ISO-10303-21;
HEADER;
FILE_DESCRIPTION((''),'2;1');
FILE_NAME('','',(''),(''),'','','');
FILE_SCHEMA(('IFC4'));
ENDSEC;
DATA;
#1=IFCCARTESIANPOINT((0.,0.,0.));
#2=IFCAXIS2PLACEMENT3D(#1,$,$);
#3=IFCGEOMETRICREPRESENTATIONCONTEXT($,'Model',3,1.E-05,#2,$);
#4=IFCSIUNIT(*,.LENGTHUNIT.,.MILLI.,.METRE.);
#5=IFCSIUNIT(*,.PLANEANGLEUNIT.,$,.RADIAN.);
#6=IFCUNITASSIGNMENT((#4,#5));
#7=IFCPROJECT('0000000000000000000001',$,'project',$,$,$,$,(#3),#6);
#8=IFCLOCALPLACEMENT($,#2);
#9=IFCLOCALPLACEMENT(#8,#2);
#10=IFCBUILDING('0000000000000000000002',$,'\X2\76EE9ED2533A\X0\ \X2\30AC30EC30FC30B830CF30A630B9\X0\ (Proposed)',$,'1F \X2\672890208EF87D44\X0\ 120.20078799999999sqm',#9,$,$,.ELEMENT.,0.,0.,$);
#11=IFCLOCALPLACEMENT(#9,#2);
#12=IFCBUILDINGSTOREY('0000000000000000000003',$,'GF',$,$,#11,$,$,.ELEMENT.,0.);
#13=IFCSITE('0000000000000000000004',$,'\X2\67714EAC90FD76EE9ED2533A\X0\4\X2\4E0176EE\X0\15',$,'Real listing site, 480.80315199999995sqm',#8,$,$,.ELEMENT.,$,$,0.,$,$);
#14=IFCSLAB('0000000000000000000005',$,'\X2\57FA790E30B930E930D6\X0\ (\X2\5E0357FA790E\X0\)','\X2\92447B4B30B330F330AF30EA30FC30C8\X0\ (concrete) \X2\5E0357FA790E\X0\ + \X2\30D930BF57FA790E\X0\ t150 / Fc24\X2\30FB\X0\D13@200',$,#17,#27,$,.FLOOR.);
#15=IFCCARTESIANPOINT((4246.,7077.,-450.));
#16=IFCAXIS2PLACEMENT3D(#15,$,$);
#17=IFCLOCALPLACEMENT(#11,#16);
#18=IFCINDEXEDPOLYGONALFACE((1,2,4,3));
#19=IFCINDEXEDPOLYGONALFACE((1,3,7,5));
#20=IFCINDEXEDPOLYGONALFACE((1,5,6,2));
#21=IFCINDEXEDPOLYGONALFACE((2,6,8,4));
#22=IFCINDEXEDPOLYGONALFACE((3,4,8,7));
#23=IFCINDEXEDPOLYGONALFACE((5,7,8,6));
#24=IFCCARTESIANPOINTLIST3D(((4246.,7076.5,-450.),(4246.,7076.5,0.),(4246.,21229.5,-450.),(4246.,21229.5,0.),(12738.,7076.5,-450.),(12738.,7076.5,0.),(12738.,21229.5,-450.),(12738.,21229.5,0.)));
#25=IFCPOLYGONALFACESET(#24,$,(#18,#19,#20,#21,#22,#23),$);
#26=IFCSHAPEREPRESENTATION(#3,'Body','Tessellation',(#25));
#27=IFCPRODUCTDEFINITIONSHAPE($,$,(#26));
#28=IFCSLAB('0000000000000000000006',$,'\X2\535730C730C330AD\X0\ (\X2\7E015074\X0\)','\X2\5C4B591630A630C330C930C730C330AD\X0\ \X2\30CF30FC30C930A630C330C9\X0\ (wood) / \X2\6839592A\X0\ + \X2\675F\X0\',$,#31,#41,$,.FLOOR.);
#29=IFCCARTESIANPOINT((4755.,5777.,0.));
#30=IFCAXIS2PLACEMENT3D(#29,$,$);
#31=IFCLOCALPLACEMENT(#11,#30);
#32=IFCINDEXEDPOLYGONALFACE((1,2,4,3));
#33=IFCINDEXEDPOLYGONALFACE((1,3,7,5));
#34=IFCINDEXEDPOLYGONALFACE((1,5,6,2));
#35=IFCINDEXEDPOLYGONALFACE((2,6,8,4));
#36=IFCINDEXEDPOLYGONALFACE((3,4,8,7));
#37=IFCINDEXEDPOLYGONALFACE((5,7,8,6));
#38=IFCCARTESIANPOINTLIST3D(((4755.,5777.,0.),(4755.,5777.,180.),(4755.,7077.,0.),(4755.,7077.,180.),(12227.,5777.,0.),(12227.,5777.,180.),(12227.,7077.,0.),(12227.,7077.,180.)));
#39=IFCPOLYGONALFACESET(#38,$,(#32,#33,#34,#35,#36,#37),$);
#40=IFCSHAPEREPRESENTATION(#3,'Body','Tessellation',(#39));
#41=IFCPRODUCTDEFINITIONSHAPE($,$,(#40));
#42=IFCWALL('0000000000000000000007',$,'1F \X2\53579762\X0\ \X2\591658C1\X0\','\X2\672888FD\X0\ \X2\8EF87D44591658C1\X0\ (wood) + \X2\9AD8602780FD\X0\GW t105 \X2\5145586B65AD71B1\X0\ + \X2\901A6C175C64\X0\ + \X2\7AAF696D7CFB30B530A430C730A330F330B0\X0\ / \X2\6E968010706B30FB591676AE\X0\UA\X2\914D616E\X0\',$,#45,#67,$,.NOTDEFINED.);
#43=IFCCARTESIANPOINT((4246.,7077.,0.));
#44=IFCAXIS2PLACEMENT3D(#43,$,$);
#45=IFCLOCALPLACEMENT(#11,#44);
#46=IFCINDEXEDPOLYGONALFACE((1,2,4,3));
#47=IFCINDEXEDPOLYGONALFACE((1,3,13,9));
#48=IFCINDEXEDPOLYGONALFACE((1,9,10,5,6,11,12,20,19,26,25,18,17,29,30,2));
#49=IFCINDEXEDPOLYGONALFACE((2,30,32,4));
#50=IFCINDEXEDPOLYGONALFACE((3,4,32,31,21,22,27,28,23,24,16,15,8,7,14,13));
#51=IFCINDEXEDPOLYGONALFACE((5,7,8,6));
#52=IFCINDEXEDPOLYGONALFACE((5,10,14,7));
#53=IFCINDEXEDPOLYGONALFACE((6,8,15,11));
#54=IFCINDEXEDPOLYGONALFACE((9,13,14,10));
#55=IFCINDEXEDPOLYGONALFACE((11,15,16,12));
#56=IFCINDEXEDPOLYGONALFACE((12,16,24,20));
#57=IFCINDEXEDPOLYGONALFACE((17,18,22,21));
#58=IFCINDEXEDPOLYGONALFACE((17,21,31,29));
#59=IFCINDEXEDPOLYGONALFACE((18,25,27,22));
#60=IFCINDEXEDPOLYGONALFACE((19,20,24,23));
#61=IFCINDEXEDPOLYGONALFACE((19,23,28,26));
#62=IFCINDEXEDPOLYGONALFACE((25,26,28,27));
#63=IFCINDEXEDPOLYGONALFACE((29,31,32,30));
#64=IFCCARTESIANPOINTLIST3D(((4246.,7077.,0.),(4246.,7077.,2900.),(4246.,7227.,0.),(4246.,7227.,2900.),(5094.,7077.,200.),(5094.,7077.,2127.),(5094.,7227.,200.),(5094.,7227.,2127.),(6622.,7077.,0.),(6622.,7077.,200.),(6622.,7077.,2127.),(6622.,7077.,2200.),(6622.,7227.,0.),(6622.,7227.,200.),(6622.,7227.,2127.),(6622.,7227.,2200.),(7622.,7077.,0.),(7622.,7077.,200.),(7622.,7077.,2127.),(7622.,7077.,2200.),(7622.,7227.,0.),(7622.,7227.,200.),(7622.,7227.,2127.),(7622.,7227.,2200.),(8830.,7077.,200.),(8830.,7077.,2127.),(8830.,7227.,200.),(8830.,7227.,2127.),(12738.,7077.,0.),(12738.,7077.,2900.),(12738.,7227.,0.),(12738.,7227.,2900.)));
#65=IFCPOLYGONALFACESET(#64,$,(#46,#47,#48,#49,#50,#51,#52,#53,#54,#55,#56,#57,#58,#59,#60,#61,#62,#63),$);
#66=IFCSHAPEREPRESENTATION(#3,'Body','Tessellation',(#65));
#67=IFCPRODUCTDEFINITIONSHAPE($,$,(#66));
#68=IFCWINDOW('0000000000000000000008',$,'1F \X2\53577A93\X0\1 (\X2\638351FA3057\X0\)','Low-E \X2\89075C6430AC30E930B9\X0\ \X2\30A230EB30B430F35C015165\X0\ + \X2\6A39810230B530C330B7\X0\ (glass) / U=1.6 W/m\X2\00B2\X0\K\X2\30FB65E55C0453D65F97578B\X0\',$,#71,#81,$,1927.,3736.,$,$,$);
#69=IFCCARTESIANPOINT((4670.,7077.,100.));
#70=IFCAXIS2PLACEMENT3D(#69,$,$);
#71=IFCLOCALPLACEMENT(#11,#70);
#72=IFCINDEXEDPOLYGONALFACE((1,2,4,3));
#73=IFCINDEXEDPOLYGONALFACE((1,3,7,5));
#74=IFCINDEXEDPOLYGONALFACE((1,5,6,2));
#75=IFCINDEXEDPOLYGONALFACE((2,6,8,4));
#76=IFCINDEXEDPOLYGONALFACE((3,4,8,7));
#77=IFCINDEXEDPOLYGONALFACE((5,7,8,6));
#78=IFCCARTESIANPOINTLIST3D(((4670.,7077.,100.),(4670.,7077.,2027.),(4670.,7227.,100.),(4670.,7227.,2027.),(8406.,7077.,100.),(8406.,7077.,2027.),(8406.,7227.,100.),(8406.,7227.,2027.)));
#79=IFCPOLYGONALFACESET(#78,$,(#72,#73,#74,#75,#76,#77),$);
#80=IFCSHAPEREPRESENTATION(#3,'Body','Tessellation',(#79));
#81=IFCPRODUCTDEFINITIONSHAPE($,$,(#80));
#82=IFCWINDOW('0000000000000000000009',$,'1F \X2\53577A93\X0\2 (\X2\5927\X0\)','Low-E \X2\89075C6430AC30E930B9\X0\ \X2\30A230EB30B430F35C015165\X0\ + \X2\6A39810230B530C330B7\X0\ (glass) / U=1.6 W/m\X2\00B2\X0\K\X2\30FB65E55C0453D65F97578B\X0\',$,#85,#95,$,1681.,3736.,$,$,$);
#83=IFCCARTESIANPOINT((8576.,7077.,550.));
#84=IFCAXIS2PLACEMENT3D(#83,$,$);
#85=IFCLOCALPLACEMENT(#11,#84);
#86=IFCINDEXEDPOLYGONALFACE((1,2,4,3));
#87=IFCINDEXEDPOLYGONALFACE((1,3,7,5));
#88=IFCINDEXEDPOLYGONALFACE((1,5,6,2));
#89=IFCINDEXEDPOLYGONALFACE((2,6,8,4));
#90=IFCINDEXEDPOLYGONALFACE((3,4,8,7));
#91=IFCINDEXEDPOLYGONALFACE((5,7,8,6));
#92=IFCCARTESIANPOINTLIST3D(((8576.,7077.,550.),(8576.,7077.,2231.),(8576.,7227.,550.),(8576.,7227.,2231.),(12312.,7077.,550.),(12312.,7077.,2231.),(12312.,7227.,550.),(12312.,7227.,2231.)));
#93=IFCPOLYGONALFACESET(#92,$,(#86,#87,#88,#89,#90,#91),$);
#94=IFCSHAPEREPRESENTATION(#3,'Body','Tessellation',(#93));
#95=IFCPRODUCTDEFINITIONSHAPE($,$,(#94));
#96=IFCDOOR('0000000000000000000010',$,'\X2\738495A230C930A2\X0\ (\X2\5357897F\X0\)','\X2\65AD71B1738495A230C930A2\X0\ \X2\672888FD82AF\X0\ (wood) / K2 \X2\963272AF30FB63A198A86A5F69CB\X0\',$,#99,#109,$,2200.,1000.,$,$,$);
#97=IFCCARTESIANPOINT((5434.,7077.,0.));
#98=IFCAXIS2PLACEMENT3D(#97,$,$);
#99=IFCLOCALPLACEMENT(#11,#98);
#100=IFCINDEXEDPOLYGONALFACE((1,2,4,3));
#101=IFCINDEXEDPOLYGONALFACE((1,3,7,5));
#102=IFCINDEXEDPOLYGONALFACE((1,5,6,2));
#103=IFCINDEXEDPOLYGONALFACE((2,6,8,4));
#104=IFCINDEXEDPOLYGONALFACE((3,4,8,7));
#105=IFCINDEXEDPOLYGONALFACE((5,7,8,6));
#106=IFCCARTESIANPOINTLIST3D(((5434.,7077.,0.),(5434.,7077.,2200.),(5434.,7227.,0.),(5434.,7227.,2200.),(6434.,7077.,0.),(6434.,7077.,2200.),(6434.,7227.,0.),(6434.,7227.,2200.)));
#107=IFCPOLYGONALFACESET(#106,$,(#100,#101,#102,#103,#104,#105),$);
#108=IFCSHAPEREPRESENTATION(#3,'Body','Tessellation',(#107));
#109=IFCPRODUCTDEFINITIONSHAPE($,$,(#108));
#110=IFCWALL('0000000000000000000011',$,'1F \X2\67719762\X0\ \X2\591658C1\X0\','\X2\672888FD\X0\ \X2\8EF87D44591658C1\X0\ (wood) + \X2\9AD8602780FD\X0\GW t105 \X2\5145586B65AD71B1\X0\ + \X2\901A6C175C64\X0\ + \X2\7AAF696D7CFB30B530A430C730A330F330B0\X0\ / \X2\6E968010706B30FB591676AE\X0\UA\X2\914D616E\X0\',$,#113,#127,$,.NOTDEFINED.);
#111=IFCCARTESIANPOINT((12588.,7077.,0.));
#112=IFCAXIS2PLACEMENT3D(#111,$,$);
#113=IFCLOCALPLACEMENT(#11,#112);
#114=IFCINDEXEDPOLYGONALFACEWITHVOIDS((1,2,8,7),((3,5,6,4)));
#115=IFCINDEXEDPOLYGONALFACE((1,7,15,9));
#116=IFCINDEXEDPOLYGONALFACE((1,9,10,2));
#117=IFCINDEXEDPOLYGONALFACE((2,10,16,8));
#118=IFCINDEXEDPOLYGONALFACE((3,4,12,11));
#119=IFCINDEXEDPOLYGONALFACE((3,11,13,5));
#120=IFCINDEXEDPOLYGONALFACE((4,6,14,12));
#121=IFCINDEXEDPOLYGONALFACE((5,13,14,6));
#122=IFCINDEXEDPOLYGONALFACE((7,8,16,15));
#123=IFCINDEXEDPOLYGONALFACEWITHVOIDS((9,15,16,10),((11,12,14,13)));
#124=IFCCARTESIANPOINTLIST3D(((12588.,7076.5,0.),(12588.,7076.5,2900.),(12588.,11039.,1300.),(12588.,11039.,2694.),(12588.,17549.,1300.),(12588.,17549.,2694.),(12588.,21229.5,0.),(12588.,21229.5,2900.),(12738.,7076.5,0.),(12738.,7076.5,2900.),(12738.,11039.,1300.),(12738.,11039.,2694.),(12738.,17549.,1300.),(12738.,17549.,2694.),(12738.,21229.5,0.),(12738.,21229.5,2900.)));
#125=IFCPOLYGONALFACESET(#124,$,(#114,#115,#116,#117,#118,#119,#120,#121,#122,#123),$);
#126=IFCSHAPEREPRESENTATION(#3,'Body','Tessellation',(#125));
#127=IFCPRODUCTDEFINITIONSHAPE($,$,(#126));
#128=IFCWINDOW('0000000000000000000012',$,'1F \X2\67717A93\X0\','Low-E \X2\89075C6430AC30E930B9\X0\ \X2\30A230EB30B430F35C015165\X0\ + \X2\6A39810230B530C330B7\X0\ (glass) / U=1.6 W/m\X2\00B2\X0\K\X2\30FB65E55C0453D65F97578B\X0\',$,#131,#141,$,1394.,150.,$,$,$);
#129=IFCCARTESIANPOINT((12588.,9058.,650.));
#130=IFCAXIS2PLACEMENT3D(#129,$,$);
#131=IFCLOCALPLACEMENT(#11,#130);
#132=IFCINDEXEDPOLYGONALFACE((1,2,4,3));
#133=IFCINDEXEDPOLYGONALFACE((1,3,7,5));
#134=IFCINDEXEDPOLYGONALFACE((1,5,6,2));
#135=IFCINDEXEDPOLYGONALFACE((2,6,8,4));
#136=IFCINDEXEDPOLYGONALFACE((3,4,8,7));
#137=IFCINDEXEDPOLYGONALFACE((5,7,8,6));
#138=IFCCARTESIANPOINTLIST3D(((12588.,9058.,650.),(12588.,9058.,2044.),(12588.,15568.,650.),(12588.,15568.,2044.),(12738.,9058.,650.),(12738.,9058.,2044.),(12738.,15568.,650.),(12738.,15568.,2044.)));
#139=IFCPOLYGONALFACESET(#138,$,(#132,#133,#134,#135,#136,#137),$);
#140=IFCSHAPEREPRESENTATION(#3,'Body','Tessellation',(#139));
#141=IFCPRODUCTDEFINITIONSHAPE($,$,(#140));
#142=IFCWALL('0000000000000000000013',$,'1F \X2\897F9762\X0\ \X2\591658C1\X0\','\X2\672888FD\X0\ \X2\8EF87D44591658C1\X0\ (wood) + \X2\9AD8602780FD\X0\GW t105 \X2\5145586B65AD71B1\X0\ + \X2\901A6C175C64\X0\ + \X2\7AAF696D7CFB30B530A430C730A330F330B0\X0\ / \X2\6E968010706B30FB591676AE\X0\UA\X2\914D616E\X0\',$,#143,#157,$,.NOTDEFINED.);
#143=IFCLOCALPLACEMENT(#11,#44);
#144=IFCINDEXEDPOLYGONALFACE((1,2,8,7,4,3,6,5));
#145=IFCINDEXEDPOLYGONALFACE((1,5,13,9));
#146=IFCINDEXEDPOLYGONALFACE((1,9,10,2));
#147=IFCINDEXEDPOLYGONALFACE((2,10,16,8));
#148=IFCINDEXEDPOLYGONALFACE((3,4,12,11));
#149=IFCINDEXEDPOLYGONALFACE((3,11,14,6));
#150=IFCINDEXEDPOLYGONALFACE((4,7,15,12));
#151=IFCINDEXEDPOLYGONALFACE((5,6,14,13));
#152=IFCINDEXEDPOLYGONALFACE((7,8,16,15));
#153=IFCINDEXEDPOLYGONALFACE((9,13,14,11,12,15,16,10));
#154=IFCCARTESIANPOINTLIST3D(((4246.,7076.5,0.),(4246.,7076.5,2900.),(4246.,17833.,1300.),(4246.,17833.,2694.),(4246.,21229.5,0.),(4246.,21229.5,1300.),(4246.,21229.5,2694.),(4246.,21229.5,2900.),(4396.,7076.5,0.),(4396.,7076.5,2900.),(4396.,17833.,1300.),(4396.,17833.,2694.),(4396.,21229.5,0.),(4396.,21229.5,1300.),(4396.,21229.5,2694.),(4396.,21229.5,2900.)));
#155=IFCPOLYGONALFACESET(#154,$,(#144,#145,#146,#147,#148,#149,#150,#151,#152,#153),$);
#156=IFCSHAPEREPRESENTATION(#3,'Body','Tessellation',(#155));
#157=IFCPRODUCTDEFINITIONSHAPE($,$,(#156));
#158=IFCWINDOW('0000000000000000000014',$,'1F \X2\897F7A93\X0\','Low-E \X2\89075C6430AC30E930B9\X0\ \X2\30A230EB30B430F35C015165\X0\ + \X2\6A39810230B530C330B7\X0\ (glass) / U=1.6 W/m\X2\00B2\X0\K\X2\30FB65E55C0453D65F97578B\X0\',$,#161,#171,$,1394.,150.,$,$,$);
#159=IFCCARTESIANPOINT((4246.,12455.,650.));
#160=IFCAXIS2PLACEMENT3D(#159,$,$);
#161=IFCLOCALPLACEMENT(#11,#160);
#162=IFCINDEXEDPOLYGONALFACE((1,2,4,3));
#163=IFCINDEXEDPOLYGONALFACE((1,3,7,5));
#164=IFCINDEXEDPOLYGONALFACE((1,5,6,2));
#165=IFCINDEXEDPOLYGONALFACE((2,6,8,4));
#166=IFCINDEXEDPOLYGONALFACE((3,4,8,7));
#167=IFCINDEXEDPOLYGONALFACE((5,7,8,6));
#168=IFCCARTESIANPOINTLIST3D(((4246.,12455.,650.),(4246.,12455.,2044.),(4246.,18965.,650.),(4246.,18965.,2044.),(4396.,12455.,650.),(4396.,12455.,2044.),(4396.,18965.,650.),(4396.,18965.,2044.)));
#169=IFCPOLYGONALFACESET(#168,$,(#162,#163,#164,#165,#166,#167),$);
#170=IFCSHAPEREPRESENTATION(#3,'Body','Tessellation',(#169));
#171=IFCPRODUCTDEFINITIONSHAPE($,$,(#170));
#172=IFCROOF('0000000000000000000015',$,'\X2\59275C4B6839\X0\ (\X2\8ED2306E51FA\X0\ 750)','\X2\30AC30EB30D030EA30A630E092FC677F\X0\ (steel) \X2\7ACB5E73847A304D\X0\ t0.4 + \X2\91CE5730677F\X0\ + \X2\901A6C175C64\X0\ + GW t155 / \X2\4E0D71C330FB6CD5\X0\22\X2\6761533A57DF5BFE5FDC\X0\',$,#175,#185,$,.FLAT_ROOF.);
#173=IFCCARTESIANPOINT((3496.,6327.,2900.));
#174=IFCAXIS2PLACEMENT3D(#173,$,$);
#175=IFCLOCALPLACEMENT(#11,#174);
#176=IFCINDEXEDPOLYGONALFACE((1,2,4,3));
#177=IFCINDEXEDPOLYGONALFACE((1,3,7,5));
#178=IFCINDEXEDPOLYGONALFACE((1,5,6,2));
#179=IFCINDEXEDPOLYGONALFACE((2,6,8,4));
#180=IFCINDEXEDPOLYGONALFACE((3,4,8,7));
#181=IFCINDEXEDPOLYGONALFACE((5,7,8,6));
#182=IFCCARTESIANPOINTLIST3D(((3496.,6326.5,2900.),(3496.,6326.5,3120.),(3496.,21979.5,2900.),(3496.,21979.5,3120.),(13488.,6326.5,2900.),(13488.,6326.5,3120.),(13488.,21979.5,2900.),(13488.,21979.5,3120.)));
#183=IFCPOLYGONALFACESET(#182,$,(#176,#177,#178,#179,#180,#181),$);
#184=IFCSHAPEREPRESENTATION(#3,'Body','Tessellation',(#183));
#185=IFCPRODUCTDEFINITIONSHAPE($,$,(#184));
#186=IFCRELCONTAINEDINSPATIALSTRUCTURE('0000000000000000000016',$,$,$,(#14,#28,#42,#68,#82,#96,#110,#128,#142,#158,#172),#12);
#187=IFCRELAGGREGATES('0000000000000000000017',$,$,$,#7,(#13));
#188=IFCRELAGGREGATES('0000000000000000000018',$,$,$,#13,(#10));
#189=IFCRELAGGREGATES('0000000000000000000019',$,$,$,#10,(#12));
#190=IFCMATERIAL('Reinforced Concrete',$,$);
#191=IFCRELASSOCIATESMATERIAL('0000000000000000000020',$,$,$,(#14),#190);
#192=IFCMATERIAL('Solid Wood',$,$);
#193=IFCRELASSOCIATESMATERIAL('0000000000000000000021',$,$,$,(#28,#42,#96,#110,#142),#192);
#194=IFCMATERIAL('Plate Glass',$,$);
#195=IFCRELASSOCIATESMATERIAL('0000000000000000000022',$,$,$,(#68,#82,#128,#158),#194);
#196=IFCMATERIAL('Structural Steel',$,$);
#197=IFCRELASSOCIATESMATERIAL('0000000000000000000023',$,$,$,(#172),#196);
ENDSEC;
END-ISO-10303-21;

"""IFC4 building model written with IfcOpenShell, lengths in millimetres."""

from ifc_helpers import new_model, si_unit, frame, frame_2d, origin, place, context, project, spatial, rectangle, extrude, material, element, fill, save


model = new_model("IFC4")

# Units and contexts
model_context = context("Model", 3, precision=1e-05, world=origin())
ifc_project = project(units=[si_unit("LENGTHUNIT", "METRE", prefix="MILLI"), si_unit("PLANEANGLEUNIT", "RADIAN")], contexts=[model_context])

# Site, building, storey
site_placement = place(None, origin())
site = spatial("IfcSite", under=ifc_project, at=site_placement, Name="東京都目黒区4丁目15", ObjectType="Real listing site, 480.80315199999995sqm", CompositionType="ELEMENT", RefElevation=0.0)
building_placement = place(site_placement, origin())
building = spatial("IfcBuilding", under=site, at=building_placement, Name="目黒区 ガレージハウス (Proposed)", ObjectType="1F 木造軸組 120.20078799999999sqm", CompositionType="ELEMENT", ElevationOfRefHeight=0.0, ElevationOfTerrain=0.0)
storey_placement = place(building_placement, origin())
storey = spatial("IfcBuildingStorey", under=building, at=storey_placement, Name="GF", CompositionType="ELEMENT", Elevation=0.0)

# Slabs
ifc_material_1 = material(Name="Reinforced Concrete")
slab_1_placement = place(storey_placement, frame((4246.0, 7077.0, -450.0)))
element("IfcSlab", 1, at=slab_1_placement, inside=storey, material=ifc_material_1, Name="基礎スラブ (布基礎)", Description="鉄筋コンクリート (concrete) 布基礎 + ベタ基礎 t150 / Fc24・D13@200", PredefinedType="FLOOR", context=model_context, shape_type="SweptSolid", body=[
    extrude(rectangle(XDim=8492.0, YDim=14153.0, at=frame_2d((4246.0, 7076.0))), frame((4246.0, 7077.0, -450.0)), (0.0, 0.0, 1.0), 450.0),
])
ifc_material_2 = material(Name="Solid Wood")
slab_2_placement = place(storey_placement, frame((4755.0, 5777.0, 0.0)))
element("IfcSlab", 2, at=slab_2_placement, inside=storey, material=ifc_material_2, Name="南デッキ (縁側)", Description="屋外ウッドデッキ ハードウッド (wood) / 根太 + 束", PredefinedType="FLOOR", context=model_context, shape_type="SweptSolid", body=[
    extrude(rectangle(XDim=7472.0, YDim=1300.0, at=frame_2d((3736.0, 650.0))), frame((4755.0, 5777.0, 0.0)), (0.0, 0.0, 1.0), 180.0),
])

# Wall, openings, windows, door
wall_1_placement = place(storey_placement, frame((4246.0, 7077.0, 0.0)))
wall_1 = element("IfcWall", 3, at=wall_1_placement, inside=storey, material=ifc_material_2, Name="1F 南面 外壁", Description="木製 軸組外壁 (wood) + 高性能GW t105 充填断熱 + 通気層 + 窯業系サイディング / 準耐火・外皮UA配慮", PredefinedType="NOTDEFINED", context=model_context, shape_type="SweptSolid", body=[
    extrude(rectangle(XDim=8492.0, YDim=150.0, at=frame_2d((4246.0, 75.0))), frame((4246.0, 7077.0, 0.0)), (0.0, 0.0, 1.0), 2900.0),
])
opening_1_placement = place(storey_placement, frame((4670.0, 7077.0, 100.0)))
opening_1 = element("IfcOpeningElement", 4, at=opening_1_placement, cuts=wall_1, PredefinedType="NOTDEFINED", context=model_context, shape_type="SweptSolid", body=[
    extrude(rectangle(XDim=3736.0, YDim=150.0, at=frame_2d((1868.0, 75.0))), frame((4670.0, 7077.0, 100.0)), (0.0, 0.0, 1.0), 1927.0),
])
opening_2_placement = place(storey_placement, frame((8576.0, 7077.0, 550.0)))
opening_2 = element("IfcOpeningElement", 5, at=opening_2_placement, cuts=wall_1, PredefinedType="NOTDEFINED", context=model_context, shape_type="SweptSolid", body=[
    extrude(rectangle(XDim=3736.0, YDim=150.0, at=frame_2d((1868.0, 75.0))), frame((8576.0, 7077.0, 550.0)), (0.0, 0.0, 1.0), 1681.0),
])
opening_3_placement = place(storey_placement, frame((5434.0, 7077.0, 0.0)))
opening_3 = element("IfcOpeningElement", 6, at=opening_3_placement, cuts=wall_1, PredefinedType="NOTDEFINED", context=model_context, shape_type="SweptSolid", body=[
    extrude(rectangle(XDim=1000.0, YDim=150.0, at=frame_2d((500.0, 75.0))), frame((5434.0, 7077.0, 0.0)), (0.0, 0.0, 1.0), 2200.0),
])
ifc_material_3 = material(Name="Plate Glass")
window_1_placement = place(storey_placement, frame((4670.0, 7077.0, 100.0)))
window_1 = element("IfcWindow", 7, at=window_1_placement, inside=storey, material=ifc_material_3, Name="1F 南窓1 (掃出し)", Description="Low-E 複層ガラス アルゴン封入 + 樹脂サッシ (glass) / U=1.6 W/m²K・日射取得型", OverallHeight=1927.0, OverallWidth=3736.0, context=model_context, shape_type="SweptSolid", body=[
    extrude(rectangle(XDim=3736.0, YDim=150.0, at=frame_2d((1868.0, 75.0))), frame((4670.0, 7077.0, 100.0)), (0.0, 0.0, 1.0), 1927.0),
])
fill(opening_1, window_1)
window_2_placement = place(storey_placement, frame((8576.0, 7077.0, 550.0)))
window_2 = element("IfcWindow", 8, at=window_2_placement, inside=storey, material=ifc_material_3, Name="1F 南窓2 (大)", Description="Low-E 複層ガラス アルゴン封入 + 樹脂サッシ (glass) / U=1.6 W/m²K・日射取得型", OverallHeight=1681.0, OverallWidth=3736.0, context=model_context, shape_type="SweptSolid", body=[
    extrude(rectangle(XDim=3736.0, YDim=150.0, at=frame_2d((1868.0, 75.0))), frame((8576.0, 7077.0, 550.0)), (0.0, 0.0, 1.0), 1681.0),
])
fill(opening_2, window_2)
door_placement = place(storey_placement, frame((5434.0, 7077.0, 0.0)))
door = element("IfcDoor", 9, at=door_placement, inside=storey, material=ifc_material_2, Name="玄関ドア (南西)", Description="断熱玄関ドア 木製芯 (wood) / K2 防犯・採風機構", OverallHeight=2200.0, OverallWidth=1000.0, context=model_context, shape_type="SweptSolid", body=[
    extrude(rectangle(XDim=1000.0, YDim=150.0, at=frame_2d((500.0, 75.0))), frame((5434.0, 7077.0, 0.0)), (0.0, 0.0, 1.0), 2200.0),
])
fill(opening_3, door)

# Walls, openings, windows
wall_2_placement = place(storey_placement, frame((12588.0, 7077.0, 0.0)))
wall_2 = element("IfcWall", 10, at=wall_2_placement, inside=storey, material=ifc_material_2, Name="1F 東面 外壁", Description="木製 軸組外壁 (wood) + 高性能GW t105 充填断熱 + 通気層 + 窯業系サイディング / 準耐火・外皮UA配慮", PredefinedType="NOTDEFINED", context=model_context, shape_type="SweptSolid", body=[
    extrude(rectangle(XDim=150.0, YDim=14153.0, at=frame_2d((75.0, 7076.0))), frame((12588.0, 7077.0, 0.0)), (0.0, 0.0, 1.0), 2900.0),
])
opening_4_placement = place(storey_placement, frame((12588.0, 9058.0, 650.0)))
opening_4 = element("IfcOpeningElement", 11, at=opening_4_placement, cuts=wall_2, PredefinedType="NOTDEFINED", context=model_context, shape_type="SweptSolid", body=[
    extrude(rectangle(XDim=150.0, YDim=6510.0, at=frame_2d((75.0, 3255.0))), frame((12588.0, 9058.0, 650.0)), (0.0, 0.0, 1.0), 1394.0),
])
window_3_placement = place(storey_placement, frame((12588.0, 9058.0, 650.0)))
window_3 = element("IfcWindow", 12, at=window_3_placement, inside=storey, material=ifc_material_3, Name="1F 東窓", Description="Low-E 複層ガラス アルゴン封入 + 樹脂サッシ (glass) / U=1.6 W/m²K・日射取得型", OverallHeight=1394.0, OverallWidth=150.0, context=model_context, shape_type="SweptSolid", body=[
    extrude(rectangle(XDim=150.0, YDim=6510.0, at=frame_2d((75.0, 3255.0))), frame((12588.0, 9058.0, 650.0)), (0.0, 0.0, 1.0), 1394.0),
])
fill(opening_4, window_3)
wall_3_placement = place(storey_placement, frame((4246.0, 7077.0, 0.0)))
wall_3 = element("IfcWall", 13, at=wall_3_placement, inside=storey, material=ifc_material_2, Name="1F 西面 外壁", Description="木製 軸組外壁 (wood) + 高性能GW t105 充填断熱 + 通気層 + 窯業系サイディング / 準耐火・外皮UA配慮", PredefinedType="NOTDEFINED", context=model_context, shape_type="SweptSolid", body=[
    extrude(rectangle(XDim=150.0, YDim=14153.0, at=frame_2d((75.0, 7076.0))), frame((4246.0, 7077.0, 0.0)), (0.0, 0.0, 1.0), 2900.0),
])
opening_5_placement = place(storey_placement, frame((4246.0, 12455.0, 650.0)))
opening_5 = element("IfcOpeningElement", 14, at=opening_5_placement, cuts=wall_3, PredefinedType="NOTDEFINED", context=model_context, shape_type="SweptSolid", body=[
    extrude(rectangle(XDim=150.0, YDim=6510.0, at=frame_2d((75.0, 3255.0))), frame((4246.0, 12455.0, 650.0)), (0.0, 0.0, 1.0), 1394.0),
])
window_4_placement = place(storey_placement, frame((4246.0, 12455.0, 650.0)))
window_4 = element("IfcWindow", 15, at=window_4_placement, inside=storey, material=ifc_material_3, Name="1F 西窓", Description="Low-E 複層ガラス アルゴン封入 + 樹脂サッシ (glass) / U=1.6 W/m²K・日射取得型", OverallHeight=1394.0, OverallWidth=150.0, context=model_context, shape_type="SweptSolid", body=[
    extrude(rectangle(XDim=150.0, YDim=6510.0, at=frame_2d((75.0, 3255.0))), frame((4246.0, 12455.0, 650.0)), (0.0, 0.0, 1.0), 1394.0),
])
fill(opening_5, window_4)

# Roof
ifc_material_4 = material(Name="Structural Steel")
roof_placement = place(storey_placement, frame((3496.0, 6327.0, 2900.0)))
element("IfcRoof", 16, at=roof_placement, inside=storey, material=ifc_material_4, Name="大屋根 (軒の出 750)", Description="ガルバリウム鋼板 (steel) 立平葺き t0.4 + 野地板 + 通気層 + GW t155 / 不燃・法22条区域対応", PredefinedType="FLAT_ROOF", context=model_context, shape_type="SweptSolid", body=[
    extrude(rectangle(XDim=9992.0, YDim=15653.0, at=frame_2d((4996.0, 7826.0))), frame((3496.0, 6327.0, 2900.0)), (0.0, 0.0, 1.0), 220.0),
])

save(model, "model.ifc")
